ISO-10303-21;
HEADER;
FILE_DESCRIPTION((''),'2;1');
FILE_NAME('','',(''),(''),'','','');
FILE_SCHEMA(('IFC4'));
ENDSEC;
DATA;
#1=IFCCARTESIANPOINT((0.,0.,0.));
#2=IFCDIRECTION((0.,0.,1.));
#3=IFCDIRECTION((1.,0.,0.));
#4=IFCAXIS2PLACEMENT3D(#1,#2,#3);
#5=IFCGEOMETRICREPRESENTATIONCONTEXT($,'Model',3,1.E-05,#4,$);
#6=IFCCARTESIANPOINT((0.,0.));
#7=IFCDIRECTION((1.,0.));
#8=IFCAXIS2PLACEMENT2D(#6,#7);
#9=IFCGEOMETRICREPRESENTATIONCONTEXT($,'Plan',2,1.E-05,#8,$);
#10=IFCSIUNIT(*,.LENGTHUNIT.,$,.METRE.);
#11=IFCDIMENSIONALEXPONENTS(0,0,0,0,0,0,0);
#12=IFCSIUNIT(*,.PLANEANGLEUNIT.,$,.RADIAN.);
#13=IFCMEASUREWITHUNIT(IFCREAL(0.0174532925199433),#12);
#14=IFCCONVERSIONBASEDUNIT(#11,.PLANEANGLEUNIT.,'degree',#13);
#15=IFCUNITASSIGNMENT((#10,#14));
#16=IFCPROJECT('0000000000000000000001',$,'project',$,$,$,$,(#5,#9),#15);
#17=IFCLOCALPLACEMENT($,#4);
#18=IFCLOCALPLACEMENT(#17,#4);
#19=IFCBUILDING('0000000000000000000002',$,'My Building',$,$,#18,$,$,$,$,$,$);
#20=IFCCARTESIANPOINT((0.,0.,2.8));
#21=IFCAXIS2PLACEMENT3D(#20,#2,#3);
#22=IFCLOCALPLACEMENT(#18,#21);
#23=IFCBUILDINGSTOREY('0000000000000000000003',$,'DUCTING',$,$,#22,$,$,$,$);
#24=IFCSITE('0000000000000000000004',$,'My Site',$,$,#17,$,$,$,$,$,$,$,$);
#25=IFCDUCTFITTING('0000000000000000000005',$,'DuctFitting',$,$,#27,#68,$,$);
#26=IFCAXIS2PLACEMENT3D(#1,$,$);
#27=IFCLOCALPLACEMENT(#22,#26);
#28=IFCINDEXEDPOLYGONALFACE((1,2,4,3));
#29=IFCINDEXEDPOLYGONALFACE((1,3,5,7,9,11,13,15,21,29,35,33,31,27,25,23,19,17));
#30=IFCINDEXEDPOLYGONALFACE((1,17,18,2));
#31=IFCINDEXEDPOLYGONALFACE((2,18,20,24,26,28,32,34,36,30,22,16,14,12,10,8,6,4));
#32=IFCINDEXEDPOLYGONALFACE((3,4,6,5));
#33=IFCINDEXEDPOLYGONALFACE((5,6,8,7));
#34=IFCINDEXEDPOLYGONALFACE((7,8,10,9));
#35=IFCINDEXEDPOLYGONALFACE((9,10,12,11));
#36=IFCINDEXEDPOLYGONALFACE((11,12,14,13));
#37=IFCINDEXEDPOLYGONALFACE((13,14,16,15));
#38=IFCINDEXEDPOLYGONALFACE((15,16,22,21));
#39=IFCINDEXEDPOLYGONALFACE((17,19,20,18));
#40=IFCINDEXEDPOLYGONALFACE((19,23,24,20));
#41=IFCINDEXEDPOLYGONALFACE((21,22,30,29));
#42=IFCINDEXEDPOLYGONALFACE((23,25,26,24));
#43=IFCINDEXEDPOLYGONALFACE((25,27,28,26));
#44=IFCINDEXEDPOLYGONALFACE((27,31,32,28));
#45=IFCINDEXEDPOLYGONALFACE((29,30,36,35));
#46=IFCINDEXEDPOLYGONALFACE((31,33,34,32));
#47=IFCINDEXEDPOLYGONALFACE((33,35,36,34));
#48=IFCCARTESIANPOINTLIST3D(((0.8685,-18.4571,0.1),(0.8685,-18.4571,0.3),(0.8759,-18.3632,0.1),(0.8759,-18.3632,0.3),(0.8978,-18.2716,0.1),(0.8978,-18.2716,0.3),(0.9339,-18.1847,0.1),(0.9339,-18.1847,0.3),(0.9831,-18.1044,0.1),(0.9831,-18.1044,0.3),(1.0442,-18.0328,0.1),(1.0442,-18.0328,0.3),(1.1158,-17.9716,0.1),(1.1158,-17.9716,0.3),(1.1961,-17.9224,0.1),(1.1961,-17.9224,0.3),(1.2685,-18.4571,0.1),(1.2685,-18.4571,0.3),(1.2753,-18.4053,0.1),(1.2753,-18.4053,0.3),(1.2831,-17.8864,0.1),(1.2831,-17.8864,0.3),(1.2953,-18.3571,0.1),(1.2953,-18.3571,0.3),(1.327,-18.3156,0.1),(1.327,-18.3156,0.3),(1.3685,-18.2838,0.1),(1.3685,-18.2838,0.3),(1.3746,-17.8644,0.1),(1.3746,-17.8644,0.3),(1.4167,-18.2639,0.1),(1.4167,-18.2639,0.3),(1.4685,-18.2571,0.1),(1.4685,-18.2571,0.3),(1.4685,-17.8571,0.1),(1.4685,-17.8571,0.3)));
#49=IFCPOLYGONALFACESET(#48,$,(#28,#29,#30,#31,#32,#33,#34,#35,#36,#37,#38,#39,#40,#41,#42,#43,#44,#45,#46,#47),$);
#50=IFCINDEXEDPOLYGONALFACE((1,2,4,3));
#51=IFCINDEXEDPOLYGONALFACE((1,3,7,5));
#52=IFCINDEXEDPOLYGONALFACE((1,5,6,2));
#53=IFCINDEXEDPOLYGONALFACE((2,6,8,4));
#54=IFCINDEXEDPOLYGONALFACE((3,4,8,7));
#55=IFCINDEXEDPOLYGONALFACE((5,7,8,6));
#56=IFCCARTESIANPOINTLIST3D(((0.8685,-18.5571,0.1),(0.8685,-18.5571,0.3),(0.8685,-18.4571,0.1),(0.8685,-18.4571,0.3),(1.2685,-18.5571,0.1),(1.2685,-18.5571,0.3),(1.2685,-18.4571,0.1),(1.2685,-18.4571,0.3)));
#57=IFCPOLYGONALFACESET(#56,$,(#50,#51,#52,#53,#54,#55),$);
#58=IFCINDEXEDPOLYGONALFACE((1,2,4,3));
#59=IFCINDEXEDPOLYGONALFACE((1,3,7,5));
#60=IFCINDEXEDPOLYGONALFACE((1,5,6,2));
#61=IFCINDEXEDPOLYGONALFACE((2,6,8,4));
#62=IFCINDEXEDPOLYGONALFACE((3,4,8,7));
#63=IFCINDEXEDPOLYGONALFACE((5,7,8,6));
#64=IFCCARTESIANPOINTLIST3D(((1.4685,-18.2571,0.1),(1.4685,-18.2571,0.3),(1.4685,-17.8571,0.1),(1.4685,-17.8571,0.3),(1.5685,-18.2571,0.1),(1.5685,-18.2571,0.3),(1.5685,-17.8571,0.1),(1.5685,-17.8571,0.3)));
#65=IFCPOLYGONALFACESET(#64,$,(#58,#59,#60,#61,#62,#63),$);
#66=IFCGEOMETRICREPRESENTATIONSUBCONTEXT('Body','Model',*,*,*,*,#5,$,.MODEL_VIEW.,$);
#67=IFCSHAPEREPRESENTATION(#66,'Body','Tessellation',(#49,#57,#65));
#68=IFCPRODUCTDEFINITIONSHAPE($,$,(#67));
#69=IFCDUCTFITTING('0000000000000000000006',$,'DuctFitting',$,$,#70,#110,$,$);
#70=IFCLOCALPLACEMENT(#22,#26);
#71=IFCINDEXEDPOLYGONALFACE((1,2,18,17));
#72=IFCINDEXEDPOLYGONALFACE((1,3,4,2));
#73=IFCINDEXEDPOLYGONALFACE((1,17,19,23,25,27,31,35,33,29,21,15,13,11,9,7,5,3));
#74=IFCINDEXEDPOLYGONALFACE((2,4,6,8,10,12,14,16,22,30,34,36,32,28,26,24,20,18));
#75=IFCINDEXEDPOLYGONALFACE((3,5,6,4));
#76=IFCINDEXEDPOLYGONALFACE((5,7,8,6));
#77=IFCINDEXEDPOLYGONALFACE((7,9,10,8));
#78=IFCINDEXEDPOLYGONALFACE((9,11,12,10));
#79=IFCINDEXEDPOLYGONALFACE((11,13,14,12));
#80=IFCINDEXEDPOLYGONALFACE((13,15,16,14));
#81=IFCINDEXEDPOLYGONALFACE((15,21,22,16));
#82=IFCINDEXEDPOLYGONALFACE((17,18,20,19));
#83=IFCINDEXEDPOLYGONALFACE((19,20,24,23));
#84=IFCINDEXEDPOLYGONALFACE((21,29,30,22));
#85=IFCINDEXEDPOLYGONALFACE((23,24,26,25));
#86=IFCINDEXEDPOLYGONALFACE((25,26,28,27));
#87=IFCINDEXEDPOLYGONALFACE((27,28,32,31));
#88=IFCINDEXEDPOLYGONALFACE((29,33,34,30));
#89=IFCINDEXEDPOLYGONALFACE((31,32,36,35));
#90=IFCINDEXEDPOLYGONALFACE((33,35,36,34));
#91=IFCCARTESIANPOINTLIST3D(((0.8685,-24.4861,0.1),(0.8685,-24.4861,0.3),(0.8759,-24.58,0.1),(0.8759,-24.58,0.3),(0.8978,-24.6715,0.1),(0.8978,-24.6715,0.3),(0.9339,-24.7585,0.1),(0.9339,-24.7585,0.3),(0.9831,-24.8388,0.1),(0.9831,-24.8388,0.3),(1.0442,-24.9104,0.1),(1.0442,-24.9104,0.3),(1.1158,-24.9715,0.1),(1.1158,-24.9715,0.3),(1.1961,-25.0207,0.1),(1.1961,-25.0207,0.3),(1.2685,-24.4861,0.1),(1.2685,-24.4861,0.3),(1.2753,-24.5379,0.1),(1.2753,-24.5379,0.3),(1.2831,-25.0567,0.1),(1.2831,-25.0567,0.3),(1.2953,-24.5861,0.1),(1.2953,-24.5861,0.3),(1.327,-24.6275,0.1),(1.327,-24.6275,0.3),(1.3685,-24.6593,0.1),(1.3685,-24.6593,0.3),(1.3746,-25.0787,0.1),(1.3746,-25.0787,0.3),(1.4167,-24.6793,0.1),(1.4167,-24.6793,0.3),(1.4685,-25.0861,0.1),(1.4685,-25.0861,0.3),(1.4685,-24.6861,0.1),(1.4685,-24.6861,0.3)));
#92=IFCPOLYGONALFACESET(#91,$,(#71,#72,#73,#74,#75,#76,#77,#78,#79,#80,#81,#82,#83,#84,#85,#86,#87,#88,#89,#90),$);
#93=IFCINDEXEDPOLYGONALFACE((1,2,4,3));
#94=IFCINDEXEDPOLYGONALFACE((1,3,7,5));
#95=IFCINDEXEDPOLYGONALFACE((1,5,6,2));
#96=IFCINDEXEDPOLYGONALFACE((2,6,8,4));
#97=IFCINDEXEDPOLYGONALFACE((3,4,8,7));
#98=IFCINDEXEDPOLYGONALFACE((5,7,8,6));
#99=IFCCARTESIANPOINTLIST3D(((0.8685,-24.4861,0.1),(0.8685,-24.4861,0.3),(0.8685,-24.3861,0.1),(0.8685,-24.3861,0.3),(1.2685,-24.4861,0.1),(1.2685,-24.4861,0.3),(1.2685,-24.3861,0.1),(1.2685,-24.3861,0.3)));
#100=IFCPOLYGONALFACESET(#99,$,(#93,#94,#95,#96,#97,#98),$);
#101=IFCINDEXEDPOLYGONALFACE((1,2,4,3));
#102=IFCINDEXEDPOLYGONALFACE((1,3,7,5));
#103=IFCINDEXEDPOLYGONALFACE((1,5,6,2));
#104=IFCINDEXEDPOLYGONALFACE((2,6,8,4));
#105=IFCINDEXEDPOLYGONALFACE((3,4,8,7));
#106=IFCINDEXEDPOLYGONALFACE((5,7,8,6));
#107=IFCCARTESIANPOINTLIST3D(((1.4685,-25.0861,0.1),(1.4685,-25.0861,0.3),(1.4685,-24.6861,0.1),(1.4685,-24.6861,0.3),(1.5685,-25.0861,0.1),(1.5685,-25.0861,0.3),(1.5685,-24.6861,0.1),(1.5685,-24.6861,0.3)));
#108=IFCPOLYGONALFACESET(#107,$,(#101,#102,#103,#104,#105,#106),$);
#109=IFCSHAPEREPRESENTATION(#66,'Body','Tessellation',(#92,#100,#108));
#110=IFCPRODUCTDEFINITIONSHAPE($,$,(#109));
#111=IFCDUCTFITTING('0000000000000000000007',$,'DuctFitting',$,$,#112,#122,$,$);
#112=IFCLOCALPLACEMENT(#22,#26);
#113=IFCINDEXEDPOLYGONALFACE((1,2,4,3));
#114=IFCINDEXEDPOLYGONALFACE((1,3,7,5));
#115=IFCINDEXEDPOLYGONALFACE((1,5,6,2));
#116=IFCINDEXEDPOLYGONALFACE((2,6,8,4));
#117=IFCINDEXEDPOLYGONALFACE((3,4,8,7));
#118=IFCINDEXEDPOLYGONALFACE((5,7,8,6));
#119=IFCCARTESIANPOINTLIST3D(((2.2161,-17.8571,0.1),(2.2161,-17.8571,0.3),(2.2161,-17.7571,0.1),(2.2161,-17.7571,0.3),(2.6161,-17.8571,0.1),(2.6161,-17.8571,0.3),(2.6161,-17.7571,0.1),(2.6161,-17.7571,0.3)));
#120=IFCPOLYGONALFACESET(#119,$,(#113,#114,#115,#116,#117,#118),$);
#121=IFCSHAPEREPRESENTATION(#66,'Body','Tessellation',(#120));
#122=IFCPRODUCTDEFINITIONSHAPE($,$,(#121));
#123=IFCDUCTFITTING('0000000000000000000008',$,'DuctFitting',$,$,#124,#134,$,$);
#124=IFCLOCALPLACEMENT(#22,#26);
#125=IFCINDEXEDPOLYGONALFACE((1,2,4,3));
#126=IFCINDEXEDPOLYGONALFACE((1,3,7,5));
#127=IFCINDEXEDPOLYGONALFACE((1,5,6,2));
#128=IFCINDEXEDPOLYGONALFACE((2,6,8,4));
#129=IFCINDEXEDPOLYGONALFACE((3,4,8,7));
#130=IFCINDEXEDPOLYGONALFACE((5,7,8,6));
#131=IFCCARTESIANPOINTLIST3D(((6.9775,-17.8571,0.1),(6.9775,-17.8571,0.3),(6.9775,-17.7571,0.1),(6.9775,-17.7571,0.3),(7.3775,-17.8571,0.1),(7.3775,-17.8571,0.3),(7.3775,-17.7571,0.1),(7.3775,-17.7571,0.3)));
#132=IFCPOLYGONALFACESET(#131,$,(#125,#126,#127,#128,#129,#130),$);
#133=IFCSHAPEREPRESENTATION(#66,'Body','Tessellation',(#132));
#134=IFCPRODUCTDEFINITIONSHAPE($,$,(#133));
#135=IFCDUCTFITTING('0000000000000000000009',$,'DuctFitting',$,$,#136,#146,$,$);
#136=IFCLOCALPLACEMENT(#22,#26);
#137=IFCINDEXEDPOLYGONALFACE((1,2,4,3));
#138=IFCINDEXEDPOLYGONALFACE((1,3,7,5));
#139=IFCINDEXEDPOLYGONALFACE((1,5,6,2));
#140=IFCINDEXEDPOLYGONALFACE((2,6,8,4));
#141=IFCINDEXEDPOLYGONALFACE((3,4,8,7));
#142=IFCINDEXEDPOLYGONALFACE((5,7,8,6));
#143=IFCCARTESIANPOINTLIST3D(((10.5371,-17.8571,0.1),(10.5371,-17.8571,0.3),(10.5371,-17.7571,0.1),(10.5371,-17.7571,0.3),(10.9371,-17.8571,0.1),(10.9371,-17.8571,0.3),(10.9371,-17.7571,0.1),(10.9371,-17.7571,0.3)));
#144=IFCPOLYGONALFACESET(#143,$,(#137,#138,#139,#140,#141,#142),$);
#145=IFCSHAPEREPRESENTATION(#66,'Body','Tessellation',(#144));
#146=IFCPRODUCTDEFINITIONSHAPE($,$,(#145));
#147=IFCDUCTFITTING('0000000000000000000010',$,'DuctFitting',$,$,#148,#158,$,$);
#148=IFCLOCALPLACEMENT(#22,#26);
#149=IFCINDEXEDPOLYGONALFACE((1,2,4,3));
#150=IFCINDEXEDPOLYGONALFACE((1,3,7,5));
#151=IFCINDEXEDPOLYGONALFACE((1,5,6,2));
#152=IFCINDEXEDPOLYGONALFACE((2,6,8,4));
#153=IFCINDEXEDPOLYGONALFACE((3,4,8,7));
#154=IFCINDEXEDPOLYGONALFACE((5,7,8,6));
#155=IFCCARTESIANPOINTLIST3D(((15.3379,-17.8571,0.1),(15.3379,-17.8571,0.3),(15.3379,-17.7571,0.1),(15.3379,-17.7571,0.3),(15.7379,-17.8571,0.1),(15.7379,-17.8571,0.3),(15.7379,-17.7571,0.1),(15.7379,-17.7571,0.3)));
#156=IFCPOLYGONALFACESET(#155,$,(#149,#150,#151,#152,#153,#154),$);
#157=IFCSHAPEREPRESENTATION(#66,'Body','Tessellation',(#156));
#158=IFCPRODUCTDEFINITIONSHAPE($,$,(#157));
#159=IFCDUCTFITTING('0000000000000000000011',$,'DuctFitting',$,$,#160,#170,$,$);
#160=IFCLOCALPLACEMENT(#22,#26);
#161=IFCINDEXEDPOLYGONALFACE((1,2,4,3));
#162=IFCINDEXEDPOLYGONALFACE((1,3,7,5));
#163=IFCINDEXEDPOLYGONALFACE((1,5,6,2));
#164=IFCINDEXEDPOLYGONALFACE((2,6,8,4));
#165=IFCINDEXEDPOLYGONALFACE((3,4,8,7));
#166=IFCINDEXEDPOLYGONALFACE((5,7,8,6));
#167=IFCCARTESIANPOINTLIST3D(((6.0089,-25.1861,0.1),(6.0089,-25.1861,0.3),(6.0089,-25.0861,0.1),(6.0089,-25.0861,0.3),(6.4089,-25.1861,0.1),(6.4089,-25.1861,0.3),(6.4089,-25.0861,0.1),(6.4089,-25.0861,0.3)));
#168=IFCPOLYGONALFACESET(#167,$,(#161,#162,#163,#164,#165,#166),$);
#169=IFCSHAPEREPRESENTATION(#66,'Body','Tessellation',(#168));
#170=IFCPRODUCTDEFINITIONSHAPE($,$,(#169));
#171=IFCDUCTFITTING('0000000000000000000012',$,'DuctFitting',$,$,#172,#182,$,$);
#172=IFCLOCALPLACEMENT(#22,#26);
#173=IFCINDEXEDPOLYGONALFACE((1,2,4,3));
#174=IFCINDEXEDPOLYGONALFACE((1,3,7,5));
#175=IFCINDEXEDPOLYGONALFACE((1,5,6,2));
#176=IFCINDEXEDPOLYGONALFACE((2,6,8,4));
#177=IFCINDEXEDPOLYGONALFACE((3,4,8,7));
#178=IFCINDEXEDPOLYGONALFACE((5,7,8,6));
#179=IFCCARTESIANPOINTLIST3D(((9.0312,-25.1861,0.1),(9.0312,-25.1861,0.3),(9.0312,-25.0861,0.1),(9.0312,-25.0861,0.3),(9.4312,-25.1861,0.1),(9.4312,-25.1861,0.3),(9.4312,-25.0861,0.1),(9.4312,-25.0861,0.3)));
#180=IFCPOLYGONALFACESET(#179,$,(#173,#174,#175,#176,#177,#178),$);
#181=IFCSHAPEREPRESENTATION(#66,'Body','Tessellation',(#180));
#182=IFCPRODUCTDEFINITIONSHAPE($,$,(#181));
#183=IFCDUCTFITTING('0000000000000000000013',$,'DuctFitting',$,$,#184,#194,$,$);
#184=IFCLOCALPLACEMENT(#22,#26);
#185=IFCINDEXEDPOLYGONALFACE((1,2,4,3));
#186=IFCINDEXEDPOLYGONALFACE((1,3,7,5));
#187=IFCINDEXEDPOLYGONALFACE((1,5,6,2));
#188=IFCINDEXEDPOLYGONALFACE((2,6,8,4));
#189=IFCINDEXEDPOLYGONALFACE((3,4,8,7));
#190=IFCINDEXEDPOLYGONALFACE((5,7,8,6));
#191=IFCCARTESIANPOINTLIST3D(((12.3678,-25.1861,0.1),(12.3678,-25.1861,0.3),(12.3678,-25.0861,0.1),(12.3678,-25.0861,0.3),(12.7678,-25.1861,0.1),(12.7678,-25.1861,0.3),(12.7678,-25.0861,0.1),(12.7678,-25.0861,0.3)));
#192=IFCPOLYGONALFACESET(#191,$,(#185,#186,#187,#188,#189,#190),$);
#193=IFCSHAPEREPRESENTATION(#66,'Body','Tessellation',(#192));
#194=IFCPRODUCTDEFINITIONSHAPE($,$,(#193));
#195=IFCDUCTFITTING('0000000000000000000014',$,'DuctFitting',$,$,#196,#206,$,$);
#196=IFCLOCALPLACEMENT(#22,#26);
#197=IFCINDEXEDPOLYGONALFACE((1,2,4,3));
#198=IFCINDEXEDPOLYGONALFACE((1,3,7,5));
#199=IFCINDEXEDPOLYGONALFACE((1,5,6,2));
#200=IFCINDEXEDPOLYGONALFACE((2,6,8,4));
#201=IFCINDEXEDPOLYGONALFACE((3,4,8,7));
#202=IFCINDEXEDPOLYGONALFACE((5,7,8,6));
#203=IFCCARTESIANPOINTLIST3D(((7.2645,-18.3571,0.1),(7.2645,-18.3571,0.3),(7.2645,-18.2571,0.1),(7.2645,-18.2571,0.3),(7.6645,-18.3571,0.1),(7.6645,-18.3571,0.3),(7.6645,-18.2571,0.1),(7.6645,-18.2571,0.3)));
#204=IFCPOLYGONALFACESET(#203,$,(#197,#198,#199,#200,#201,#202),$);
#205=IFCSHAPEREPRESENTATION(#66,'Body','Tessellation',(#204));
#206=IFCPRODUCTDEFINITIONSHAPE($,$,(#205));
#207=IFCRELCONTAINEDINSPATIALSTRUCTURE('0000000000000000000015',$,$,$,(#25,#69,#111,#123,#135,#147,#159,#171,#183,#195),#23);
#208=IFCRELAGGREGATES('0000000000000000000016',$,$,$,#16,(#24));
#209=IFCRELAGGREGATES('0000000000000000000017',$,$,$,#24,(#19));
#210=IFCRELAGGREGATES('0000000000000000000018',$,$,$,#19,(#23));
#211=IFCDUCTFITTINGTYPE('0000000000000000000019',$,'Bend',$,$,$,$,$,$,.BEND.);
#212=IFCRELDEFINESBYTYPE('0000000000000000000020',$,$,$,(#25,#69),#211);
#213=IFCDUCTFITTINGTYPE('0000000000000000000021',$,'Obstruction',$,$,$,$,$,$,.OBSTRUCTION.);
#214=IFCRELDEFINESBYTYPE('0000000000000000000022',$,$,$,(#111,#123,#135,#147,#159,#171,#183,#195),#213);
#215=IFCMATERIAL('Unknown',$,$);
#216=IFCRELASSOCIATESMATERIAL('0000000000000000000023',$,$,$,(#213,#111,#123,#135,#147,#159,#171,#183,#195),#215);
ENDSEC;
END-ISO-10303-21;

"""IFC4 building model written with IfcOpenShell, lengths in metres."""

from ifc_helpers import new_model, entity, si_unit, converted_unit, frame, origin_with_axes, origin_2d_with_axis, place, context, subcontext, project, spatial, line, arc, indexed_curve, rectangle, outline, extrude, source, transform, mapped, material, material_profile, profile_set, profile_usage, type_object, type_shapes, element, save


model = new_model("IFC4")

# Units and contexts
model_context = context("Model", 3, precision=1e-05, world=origin_with_axes())
plan_context = context("Plan", 2, precision=1e-05, world=origin_2d_with_axis())
body_context = subcontext(model_context, "Body", "Model", "MODEL_VIEW")
ifc_project = project(units=[si_unit("LENGTHUNIT", "METRE"), converted_unit("PLANEANGLEUNIT", "degree", entity("IfcReal", 0.0174532925199433), si_unit("PLANEANGLEUNIT", "RADIAN"), dimensions=[0, 0, 0, 0, 0, 0, 0])], contexts=[model_context, plan_context])

# Site, building, storey
site_placement = place(None, origin_with_axes())
site = spatial("IfcSite", under=ifc_project, at=site_placement, Name="My Site")
building_placement = place(site_placement, origin_with_axes())
building = spatial("IfcBuilding", under=site, at=building_placement, Name="My Building")
storey_placement = place(building_placement, frame((0.0, 0.0, 2.8), z_axis=(0.0, 0.0, 1.0), x_axis=(1.0, 0.0, 0.0)))
storey = spatial("IfcBuildingStorey", under=building, at=storey_placement, Name="DUCTING")

# Shared definitions
ifc_material = material(Name="Unknown")

# Duct fittings
duct_fitting_type_1 = type_object("IfcDuctFittingType", Name="Bend", PredefinedType="BEND")
shared_shape = source(origin_with_axes(), body_context, "Body", "SweptSolid", [
    extrude(outline(indexed_curve([(0.2, 0.0), (0.2586, -0.1414), (0.4, -0.2), (0.4, -0.6), (-0.0243, -0.4243), (-0.2, 0.0)], segments=[arc(1, 2, 3), line(3, 4), arc(4, 5, 6), line(6, 1)])), frame((0.0, -0.1, -0.1), z_axis=(0.0, -1.0, 0.0), x_axis=(1.0, 0.0, 0.0)), (0.0, 0.0, -1.0), 0.2),
    extrude(rectangle(XDim=0.4, YDim=0.2), origin_with_axes(), (0.0, 0.0, -1.0), 0.1),
    extrude(rectangle(XDim=0.4, YDim=0.2), frame((0.4, 0.0, -0.5), z_axis=(1.0, 0.0, 0.0), x_axis=(0.0, 0.0, 1.0)), (0.0, 0.0, 1.0), 0.1),
])
type_shapes(duct_fitting_type_1, [shared_shape])
for number, where, z_axis, x_axis, name in (
    (1, (1.0685, -18.5571, 0.2), (0.0, -1.0, 0.0), (1.0, 0.0, 0.0), "DuctFitting"),
    (2, (1.0685, -24.3861, 0.2), (0.0, 1.0, 0.0), (1.0, 0.0, 0.0), "DuctFitting"),
):
    element("IfcDuctFitting", number, at=place(storey_placement, frame(where, z_axis=z_axis, x_axis=x_axis)), inside=storey, type_object=duct_fitting_type_1, Name=name, context=body_context, shape_type="MappedRepresentation", body=[
        mapped(shared_shape, transform((0.0, 0.0, 0.0), x_axis=(1.0, 0.0, 0.0), y_axis=(0.0, 1.0, 0.0), z_axis=(0.0, 0.0, 1.0), scale=1.0)),
    ])
ifc_material_profile_1 = material_profile(ifc_material, rectangle(XDim=0.4, YDim=0.2))
ifc_profile_set_1 = profile_set([ifc_material_profile_1])
ifc_profile_usage_1 = profile_usage(ifc_profile_set_1, cardinal=5)
duct_fitting_type_2 = type_object("IfcDuctFittingType", Name="Obstruction", PredefinedType="OBSTRUCTION", material=ifc_profile_set_1)
duct_fitting_1_placement = place(storey_placement, frame((2.4161, -17.8571, 0.2), z_axis=(0.0, 1.0, 0.0), x_axis=(-1.0, 0.0, 0.0)))
element("IfcDuctFitting", 3, at=duct_fitting_1_placement, inside=storey, type_object=duct_fitting_type_2, material=ifc_profile_usage_1, Name="DuctFitting", context=body_context, shape_type="SweptSolid", body=[
    extrude(rectangle(XDim=0.4, YDim=0.2), origin_with_axes(), (0.0, 0.0, 1.0), 0.1),
])
ifc_profile_usage_2 = profile_usage(ifc_profile_set_1, cardinal=5)
duct_fitting_2_placement = place(storey_placement, frame((7.1775, -17.8571, 0.2), z_axis=(0.0, 1.0, 0.0), x_axis=(-1.0, 0.0, 0.0)))
element("IfcDuctFitting", 4, at=duct_fitting_2_placement, inside=storey, type_object=duct_fitting_type_2, material=ifc_profile_usage_2, Name="DuctFitting", context=body_context, shape_type="SweptSolid", body=[
    extrude(rectangle(XDim=0.4, YDim=0.2), origin_with_axes(), (0.0, 0.0, 1.0), 0.1),
])
ifc_profile_usage_3 = profile_usage(ifc_profile_set_1, cardinal=5)
duct_fitting_3_placement = place(storey_placement, frame((10.7371, -17.8571, 0.2), z_axis=(0.0, 1.0, 0.0), x_axis=(-1.0, 0.0, 0.0)))
element("IfcDuctFitting", 5, at=duct_fitting_3_placement, inside=storey, type_object=duct_fitting_type_2, material=ifc_profile_usage_3, Name="DuctFitting", context=body_context, shape_type="SweptSolid", body=[
    extrude(rectangle(XDim=0.4, YDim=0.2), origin_with_axes(), (0.0, 0.0, 1.0), 0.1),
])
ifc_profile_usage_4 = profile_usage(ifc_profile_set_1, cardinal=5)
duct_fitting_4_placement = place(storey_placement, frame((15.5379, -17.8571, 0.2), z_axis=(0.0, 1.0, 0.0), x_axis=(-1.0, 0.0, 0.0)))
element("IfcDuctFitting", 6, at=duct_fitting_4_placement, inside=storey, type_object=duct_fitting_type_2, material=ifc_profile_usage_4, Name="DuctFitting", context=body_context, shape_type="SweptSolid", body=[
    extrude(rectangle(XDim=0.4, YDim=0.2), origin_with_axes(), (0.0, 0.0, 1.0), 0.1),
])
ifc_profile_usage_5 = profile_usage(ifc_profile_set_1, cardinal=5)
duct_fitting_5_placement = place(storey_placement, frame((6.2089, -25.0861, 0.2), z_axis=(0.0, -1.0, 0.0), x_axis=(1.0, 0.0, 0.0)))
element("IfcDuctFitting", 7, at=duct_fitting_5_placement, inside=storey, type_object=duct_fitting_type_2, material=ifc_profile_usage_5, Name="DuctFitting", context=body_context, shape_type="SweptSolid", body=[
    extrude(rectangle(XDim=0.4, YDim=0.2), origin_with_axes(), (0.0, 0.0, 1.0), 0.1),
])
ifc_profile_usage_6 = profile_usage(ifc_profile_set_1, cardinal=5)
duct_fitting_6_placement = place(storey_placement, frame((9.2312, -25.0861, 0.2), z_axis=(0.0, -1.0, 0.0), x_axis=(1.0, 0.0, 0.0)))
element("IfcDuctFitting", 8, at=duct_fitting_6_placement, inside=storey, type_object=duct_fitting_type_2, material=ifc_profile_usage_6, Name="DuctFitting", context=body_context, shape_type="SweptSolid", body=[
    extrude(rectangle(XDim=0.4, YDim=0.2), origin_with_axes(), (0.0, 0.0, 1.0), 0.1),
])
ifc_profile_usage_7 = profile_usage(ifc_profile_set_1, cardinal=5)
duct_fitting_7_placement = place(storey_placement, frame((12.5678, -25.0861, 0.2), z_axis=(0.0, -1.0, 0.0), x_axis=(1.0, 0.0, 0.0)))
element("IfcDuctFitting", 9, at=duct_fitting_7_placement, inside=storey, type_object=duct_fitting_type_2, material=ifc_profile_usage_7, Name="DuctFitting", context=body_context, shape_type="SweptSolid", body=[
    extrude(rectangle(XDim=0.4, YDim=0.2), origin_with_axes(), (0.0, 0.0, 1.0), 0.1),
])
ifc_profile_usage_8 = profile_usage(ifc_profile_set_1, cardinal=5)
duct_fitting_8_placement = place(storey_placement, frame((7.4645, -18.2571, 0.2), z_axis=(0.0, -1.0, 0.0), x_axis=(1.0, 0.0, 0.0)))
element("IfcDuctFitting", 10, at=duct_fitting_8_placement, inside=storey, type_object=duct_fitting_type_2, material=ifc_profile_usage_8, Name="DuctFitting", context=body_context, shape_type="SweptSolid", body=[
    extrude(rectangle(XDim=0.4, YDim=0.2), origin_with_axes(), (0.0, 0.0, 1.0), 0.1),
])

save(model, "model.ifc")
